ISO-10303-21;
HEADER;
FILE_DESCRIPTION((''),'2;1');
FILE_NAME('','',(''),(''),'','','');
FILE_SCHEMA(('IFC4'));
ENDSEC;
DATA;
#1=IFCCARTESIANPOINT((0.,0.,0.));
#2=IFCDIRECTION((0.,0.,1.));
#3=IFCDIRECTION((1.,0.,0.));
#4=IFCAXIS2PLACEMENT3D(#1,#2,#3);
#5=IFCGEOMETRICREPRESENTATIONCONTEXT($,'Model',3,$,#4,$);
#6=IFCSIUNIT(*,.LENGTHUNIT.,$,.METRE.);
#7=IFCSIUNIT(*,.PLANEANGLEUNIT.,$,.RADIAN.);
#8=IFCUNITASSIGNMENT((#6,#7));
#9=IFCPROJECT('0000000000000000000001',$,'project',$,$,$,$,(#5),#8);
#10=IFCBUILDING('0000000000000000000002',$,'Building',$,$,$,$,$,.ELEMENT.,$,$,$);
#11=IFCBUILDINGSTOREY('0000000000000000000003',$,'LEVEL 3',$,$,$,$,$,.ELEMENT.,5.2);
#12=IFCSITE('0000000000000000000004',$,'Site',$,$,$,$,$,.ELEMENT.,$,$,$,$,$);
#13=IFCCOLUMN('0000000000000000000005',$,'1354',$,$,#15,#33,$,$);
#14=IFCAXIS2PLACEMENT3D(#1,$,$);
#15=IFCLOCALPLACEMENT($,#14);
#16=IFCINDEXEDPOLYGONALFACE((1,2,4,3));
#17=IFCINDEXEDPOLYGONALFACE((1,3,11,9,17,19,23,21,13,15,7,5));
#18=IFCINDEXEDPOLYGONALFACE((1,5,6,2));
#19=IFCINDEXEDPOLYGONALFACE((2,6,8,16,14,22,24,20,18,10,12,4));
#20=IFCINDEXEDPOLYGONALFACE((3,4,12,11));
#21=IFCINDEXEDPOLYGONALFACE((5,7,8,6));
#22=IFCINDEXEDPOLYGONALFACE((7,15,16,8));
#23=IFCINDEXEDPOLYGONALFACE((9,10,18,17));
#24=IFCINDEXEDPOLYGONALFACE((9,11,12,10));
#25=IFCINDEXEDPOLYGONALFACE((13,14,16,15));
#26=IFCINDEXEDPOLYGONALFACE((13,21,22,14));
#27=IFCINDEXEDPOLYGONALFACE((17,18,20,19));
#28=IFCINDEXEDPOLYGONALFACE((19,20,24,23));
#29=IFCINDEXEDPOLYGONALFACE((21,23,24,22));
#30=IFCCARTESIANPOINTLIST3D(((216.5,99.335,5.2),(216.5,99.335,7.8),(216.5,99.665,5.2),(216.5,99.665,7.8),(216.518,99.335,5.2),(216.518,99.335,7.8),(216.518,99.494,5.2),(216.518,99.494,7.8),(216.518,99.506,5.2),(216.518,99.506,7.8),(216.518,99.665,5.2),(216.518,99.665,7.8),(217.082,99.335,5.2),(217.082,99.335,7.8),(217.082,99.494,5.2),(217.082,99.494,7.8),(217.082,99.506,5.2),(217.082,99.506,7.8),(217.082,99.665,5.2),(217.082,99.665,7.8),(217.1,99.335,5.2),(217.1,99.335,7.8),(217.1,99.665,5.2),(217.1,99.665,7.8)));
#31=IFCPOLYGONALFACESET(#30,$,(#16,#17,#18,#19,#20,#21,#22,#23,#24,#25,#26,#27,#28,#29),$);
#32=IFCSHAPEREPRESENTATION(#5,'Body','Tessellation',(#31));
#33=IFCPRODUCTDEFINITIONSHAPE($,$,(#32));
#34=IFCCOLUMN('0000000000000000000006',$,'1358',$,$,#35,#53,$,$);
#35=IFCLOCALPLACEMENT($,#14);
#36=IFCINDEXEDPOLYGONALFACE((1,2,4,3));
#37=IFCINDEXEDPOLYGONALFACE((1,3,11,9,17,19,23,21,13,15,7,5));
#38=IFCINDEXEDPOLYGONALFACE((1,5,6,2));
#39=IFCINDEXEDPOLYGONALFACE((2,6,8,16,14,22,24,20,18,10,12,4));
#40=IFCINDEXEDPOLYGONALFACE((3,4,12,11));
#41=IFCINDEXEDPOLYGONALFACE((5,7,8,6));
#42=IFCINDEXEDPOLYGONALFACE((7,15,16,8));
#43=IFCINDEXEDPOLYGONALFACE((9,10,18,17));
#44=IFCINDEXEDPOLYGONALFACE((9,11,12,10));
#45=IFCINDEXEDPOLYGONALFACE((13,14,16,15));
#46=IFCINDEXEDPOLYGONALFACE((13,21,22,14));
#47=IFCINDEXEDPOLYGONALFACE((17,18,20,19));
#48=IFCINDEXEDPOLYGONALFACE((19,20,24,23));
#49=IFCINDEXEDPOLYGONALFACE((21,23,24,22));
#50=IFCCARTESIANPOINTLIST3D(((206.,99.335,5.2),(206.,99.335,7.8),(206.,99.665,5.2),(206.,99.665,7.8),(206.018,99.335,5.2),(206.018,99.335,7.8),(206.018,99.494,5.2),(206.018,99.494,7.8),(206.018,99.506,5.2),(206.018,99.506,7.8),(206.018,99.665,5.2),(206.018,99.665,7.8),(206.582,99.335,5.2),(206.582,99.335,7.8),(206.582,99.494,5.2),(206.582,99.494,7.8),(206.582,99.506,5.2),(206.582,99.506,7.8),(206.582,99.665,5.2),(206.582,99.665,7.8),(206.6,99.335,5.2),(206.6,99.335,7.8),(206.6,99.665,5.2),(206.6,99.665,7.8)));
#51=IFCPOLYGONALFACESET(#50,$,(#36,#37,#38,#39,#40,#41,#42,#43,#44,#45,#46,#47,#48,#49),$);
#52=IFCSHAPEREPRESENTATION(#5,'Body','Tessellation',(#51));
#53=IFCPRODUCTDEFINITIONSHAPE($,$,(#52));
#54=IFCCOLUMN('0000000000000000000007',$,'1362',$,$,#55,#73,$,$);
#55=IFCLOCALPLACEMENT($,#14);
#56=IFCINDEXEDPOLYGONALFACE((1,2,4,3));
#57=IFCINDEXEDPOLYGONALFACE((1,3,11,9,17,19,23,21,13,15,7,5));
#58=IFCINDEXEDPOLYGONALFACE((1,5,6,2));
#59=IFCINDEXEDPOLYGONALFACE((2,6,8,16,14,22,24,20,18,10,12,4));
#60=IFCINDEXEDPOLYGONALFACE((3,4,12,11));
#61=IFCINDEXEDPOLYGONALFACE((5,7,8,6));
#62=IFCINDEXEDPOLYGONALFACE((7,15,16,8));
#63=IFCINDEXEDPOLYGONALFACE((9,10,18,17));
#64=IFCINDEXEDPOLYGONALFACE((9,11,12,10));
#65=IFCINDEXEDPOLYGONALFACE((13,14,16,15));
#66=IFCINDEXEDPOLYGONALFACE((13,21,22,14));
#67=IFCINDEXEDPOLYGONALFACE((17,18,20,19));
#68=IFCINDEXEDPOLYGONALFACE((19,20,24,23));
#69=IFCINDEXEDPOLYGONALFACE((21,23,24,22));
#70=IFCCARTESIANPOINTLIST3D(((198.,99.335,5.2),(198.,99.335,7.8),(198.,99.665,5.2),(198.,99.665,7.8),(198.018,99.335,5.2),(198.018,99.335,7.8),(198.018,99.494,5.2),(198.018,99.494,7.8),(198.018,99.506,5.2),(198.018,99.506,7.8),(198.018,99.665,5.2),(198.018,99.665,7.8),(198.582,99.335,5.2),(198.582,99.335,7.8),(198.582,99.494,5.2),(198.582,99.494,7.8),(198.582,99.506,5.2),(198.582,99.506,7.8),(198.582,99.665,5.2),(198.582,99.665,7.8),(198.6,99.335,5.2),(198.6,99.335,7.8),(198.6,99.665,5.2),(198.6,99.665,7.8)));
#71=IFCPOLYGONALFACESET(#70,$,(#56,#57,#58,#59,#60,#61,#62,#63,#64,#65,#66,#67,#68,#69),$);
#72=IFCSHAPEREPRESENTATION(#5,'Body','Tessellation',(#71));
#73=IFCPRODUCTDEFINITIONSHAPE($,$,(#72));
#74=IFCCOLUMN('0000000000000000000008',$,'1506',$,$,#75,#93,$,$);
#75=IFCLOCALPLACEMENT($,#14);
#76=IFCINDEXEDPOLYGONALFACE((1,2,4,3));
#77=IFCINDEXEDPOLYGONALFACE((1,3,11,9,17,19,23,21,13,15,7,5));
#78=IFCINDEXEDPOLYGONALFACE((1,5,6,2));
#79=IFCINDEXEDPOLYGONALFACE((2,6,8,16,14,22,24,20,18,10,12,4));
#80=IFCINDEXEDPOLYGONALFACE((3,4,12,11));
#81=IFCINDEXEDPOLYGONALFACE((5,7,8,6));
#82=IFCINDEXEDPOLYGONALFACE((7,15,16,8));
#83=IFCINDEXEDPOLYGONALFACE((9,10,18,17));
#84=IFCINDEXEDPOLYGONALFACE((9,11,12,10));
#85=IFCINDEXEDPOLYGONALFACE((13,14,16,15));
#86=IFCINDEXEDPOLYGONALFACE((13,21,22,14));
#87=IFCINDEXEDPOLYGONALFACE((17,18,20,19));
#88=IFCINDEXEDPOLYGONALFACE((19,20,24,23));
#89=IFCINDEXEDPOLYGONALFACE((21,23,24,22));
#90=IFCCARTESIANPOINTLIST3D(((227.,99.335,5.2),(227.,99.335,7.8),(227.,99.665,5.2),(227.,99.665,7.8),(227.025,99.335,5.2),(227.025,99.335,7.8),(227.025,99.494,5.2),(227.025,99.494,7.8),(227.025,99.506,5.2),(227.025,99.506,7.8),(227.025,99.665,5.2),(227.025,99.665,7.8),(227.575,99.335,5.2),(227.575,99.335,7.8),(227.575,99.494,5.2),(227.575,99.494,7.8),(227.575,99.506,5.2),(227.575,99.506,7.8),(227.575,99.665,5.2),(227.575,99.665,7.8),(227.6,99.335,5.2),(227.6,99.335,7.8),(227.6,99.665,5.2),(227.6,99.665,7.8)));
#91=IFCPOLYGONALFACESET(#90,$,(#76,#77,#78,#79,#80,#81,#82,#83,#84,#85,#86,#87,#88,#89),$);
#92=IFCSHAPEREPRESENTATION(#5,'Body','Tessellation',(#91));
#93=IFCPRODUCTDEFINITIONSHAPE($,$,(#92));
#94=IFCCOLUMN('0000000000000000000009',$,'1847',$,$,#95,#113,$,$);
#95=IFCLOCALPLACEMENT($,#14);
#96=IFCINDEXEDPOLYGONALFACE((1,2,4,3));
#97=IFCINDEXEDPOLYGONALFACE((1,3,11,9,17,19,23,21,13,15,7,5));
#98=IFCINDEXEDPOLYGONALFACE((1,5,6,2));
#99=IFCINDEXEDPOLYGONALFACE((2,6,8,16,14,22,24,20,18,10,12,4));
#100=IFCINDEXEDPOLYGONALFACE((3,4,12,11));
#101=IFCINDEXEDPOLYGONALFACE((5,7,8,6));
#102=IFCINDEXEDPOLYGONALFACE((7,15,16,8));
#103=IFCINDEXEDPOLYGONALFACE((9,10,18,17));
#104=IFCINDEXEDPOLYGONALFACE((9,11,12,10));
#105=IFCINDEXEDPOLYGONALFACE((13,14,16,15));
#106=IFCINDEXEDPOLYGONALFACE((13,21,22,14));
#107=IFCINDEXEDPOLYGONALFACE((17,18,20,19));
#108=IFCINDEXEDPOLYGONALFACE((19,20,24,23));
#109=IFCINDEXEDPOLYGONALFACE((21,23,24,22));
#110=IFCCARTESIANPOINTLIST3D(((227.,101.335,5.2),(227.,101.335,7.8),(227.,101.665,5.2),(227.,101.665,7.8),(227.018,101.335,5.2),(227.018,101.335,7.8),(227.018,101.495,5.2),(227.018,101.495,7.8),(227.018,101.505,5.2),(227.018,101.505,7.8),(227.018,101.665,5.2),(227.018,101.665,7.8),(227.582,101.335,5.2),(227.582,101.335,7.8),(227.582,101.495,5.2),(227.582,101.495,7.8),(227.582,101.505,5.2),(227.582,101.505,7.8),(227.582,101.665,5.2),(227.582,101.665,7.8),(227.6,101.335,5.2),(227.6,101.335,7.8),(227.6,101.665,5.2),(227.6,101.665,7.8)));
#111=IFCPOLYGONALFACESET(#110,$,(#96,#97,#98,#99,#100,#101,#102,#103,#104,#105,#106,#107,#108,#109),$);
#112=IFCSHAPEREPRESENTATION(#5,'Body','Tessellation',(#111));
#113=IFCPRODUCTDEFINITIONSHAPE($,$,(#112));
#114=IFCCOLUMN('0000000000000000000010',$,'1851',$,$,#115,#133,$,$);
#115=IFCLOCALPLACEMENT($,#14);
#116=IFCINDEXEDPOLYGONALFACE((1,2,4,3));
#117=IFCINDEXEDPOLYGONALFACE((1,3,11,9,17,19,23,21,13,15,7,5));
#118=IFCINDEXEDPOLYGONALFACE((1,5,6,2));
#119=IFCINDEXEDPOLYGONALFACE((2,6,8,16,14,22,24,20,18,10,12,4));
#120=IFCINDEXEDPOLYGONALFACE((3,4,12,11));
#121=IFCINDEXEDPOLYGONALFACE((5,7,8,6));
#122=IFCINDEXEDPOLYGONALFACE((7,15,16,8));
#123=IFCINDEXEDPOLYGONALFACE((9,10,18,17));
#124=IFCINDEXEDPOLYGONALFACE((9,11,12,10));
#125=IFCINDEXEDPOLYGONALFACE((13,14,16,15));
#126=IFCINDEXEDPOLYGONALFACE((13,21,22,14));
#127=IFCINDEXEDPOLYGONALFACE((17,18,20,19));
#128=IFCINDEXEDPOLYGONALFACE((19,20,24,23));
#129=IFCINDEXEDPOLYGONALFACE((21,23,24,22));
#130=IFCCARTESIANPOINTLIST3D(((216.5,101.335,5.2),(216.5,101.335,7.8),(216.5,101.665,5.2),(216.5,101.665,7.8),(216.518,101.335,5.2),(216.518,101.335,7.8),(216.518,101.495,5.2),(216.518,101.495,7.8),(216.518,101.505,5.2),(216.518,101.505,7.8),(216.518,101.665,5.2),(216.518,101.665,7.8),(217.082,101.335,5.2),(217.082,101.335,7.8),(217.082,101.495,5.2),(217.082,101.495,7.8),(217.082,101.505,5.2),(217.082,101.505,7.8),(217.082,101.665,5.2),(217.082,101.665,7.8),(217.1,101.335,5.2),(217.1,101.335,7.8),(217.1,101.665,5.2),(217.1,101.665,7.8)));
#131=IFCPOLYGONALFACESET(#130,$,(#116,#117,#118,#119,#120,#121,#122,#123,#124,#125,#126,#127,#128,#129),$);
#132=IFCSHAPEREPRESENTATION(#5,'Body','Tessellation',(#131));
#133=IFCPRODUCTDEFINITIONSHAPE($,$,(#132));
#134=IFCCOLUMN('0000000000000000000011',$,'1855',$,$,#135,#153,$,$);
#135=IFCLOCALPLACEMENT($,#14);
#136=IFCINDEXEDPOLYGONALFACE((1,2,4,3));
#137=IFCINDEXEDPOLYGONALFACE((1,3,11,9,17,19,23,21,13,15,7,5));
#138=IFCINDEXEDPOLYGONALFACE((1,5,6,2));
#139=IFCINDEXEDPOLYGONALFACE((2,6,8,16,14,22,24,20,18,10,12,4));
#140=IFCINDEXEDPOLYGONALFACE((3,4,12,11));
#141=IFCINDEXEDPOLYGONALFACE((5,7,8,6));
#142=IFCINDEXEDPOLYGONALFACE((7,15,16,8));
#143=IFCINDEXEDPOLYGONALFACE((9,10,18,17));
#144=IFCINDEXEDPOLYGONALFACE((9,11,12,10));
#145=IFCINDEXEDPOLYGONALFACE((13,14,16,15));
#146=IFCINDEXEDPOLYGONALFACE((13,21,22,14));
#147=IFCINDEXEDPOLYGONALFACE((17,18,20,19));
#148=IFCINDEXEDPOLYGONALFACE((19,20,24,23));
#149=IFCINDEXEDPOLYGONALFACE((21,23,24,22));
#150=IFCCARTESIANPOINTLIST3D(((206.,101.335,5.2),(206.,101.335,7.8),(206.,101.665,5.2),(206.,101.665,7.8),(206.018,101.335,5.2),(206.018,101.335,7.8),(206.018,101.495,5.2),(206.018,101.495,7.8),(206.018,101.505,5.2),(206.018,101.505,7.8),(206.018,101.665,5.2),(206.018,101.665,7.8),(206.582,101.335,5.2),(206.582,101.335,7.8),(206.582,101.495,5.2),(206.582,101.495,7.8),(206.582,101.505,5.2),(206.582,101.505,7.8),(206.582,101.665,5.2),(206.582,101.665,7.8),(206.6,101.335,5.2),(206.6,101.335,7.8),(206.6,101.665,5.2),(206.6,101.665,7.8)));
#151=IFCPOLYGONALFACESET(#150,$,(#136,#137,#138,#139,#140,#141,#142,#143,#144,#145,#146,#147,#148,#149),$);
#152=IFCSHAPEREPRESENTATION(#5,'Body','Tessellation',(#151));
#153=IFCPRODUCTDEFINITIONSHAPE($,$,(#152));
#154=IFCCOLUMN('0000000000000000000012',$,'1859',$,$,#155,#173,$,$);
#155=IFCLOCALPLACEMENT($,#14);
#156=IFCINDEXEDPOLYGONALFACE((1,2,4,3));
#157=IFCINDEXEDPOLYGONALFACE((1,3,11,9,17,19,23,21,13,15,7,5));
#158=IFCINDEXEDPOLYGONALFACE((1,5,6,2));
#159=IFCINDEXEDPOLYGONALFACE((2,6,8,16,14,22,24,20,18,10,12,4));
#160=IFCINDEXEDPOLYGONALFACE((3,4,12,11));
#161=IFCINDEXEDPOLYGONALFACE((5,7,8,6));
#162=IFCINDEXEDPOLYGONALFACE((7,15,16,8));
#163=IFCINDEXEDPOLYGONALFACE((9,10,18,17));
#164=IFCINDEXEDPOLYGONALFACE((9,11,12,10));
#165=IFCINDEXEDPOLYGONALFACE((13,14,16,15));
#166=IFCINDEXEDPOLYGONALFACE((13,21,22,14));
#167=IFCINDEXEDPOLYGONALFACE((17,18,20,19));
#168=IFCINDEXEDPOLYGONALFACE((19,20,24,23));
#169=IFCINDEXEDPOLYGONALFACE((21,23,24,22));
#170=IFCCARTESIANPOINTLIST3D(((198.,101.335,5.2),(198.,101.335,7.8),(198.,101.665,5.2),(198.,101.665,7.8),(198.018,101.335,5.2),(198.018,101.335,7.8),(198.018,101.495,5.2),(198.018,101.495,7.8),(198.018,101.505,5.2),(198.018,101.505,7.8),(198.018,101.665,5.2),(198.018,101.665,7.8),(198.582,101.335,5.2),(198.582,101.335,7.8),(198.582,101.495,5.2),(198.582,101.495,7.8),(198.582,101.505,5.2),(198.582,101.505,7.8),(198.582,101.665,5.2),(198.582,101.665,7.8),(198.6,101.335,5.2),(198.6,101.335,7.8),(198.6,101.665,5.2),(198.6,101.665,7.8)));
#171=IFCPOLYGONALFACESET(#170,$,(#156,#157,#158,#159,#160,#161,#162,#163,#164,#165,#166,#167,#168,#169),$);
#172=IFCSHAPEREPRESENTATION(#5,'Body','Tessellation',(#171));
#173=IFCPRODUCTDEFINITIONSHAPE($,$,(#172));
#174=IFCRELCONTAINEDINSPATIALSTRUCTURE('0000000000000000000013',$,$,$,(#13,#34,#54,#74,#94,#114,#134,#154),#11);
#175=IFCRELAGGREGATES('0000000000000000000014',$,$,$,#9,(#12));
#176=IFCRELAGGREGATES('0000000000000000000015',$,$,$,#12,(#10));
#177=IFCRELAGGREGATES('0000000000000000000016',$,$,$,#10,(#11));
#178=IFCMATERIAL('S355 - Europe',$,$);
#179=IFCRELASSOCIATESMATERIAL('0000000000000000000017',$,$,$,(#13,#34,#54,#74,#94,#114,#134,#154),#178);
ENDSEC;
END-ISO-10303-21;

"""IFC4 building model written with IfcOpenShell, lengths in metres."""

from ifc_helpers import new_model, si_unit, frame, origin_with_axes, origin_2d_with_axis, place, context, project, spatial, i_section, extrude, material, material_profile, profile_set, profile_usage, element, save


model = new_model("IFC4")

# Units and contexts
model_context = context("Model", 3, world=origin_with_axes())
ifc_project = project(units=[si_unit("LENGTHUNIT", "METRE"), si_unit("PLANEANGLEUNIT", "RADIAN")], contexts=[model_context])

# Site, building, storey
site = spatial("IfcSite", under=ifc_project, Name="Site", CompositionType="ELEMENT")
building = spatial("IfcBuilding", under=site, Name="Building", CompositionType="ELEMENT")
storey = spatial("IfcBuildingStorey", under=building, Name="LEVEL 3", CompositionType="ELEMENT", Elevation=5.2)

# Columns
ifc_material = material(Name="S355 - Europe")
ifc_material_profile_1 = material_profile(ifc_material, i_section(OverallWidth=0.33, OverallDepth=0.6, WebThickness=0.012, FlangeThickness=0.018, at=origin_2d_with_axis()))
ifc_profile_set_1 = profile_set([ifc_material_profile_1])
ifc_profile_usage_1 = profile_usage(ifc_profile_set_1, cardinal=10)
column_1_placement = place(None, frame((216.8, 99.5, 5.2), z_axis=(0.0, 0.0, 1.0), x_axis=(0.0, -1.0, 0.0)))
element("IfcColumn", 1, at=column_1_placement, inside=storey, material=ifc_profile_usage_1, Name="1354", context=model_context, shape_type="SweptSolid", body=[
    extrude(i_section(OverallWidth=0.33, OverallDepth=0.6, WebThickness=0.012, FlangeThickness=0.018, at=origin_2d_with_axis()), origin_with_axes(), (0.0, 0.0, 1.0), 2.6),
])
ifc_material_profile_2 = material_profile(ifc_material, i_section(OverallWidth=0.33, OverallDepth=0.6, WebThickness=0.012, FlangeThickness=0.018, at=origin_2d_with_axis()))
ifc_profile_set_2 = profile_set([ifc_material_profile_2])
ifc_profile_usage_2 = profile_usage(ifc_profile_set_2, cardinal=10)
column_2_placement = place(None, frame((206.3, 99.5, 5.2), z_axis=(0.0, 0.0, 1.0), x_axis=(0.0, -1.0, 0.0)))
element("IfcColumn", 2, at=column_2_placement, inside=storey, material=ifc_profile_usage_2, Name="1358", context=model_context, shape_type="SweptSolid", body=[
    extrude(i_section(OverallWidth=0.33, OverallDepth=0.6, WebThickness=0.012, FlangeThickness=0.018, at=origin_2d_with_axis()), origin_with_axes(), (0.0, 0.0, 1.0), 2.6),
])
ifc_material_profile_3 = material_profile(ifc_material, i_section(OverallWidth=0.33, OverallDepth=0.6, WebThickness=0.012, FlangeThickness=0.018, at=origin_2d_with_axis()))
ifc_profile_set_3 = profile_set([ifc_material_profile_3])
ifc_profile_usage_3 = profile_usage(ifc_profile_set_3, cardinal=10)
column_3_placement = place(None, frame((198.3, 99.5, 5.2), z_axis=(0.0, 0.0, 1.0), x_axis=(0.0, -1.0, 0.0)))
element("IfcColumn", 3, at=column_3_placement, inside=storey, material=ifc_profile_usage_3, Name="1362", context=model_context, shape_type="SweptSolid", body=[
    extrude(i_section(OverallWidth=0.33, OverallDepth=0.6, WebThickness=0.012, FlangeThickness=0.018, at=origin_2d_with_axis()), origin_with_axes(), (0.0, 0.0, 1.0), 2.6),
])
ifc_material_profile_4 = material_profile(ifc_material, i_section(OverallWidth=0.33, OverallDepth=0.6, WebThickness=0.012, FlangeThickness=0.025, at=origin_2d_with_axis()))
ifc_profile_set_4 = profile_set([ifc_material_profile_4])
ifc_profile_usage_4 = profile_usage(ifc_profile_set_4, cardinal=10)
column_4_placement = place(None, frame((227.3, 99.5, 5.2), z_axis=(0.0, 0.0, 1.0), x_axis=(0.0, -1.0, 0.0)))
element("IfcColumn", 4, at=column_4_placement, inside=storey, material=ifc_profile_usage_4, Name="1506", context=model_context, shape_type="SweptSolid", body=[
    extrude(i_section(OverallWidth=0.33, OverallDepth=0.6, WebThickness=0.012, FlangeThickness=0.025, at=origin_2d_with_axis()), origin_with_axes(), (0.0, 0.0, 1.0), 2.6),
])
ifc_material_profile_5 = material_profile(ifc_material, i_section(OverallWidth=0.33, OverallDepth=0.6, WebThickness=0.01, FlangeThickness=0.018, at=origin_2d_with_axis()))
ifc_profile_set_5 = profile_set([ifc_material_profile_5])
ifc_profile_usage_5 = profile_usage(ifc_profile_set_5, cardinal=10)
column_5_placement = place(None, frame((227.3, 101.5, 5.2), z_axis=(0.0, 0.0, 1.0), x_axis=(0.0, -1.0, 0.0)))
element("IfcColumn", 5, at=column_5_placement, inside=storey, material=ifc_profile_usage_5, Name="1847", context=model_context, shape_type="SweptSolid", body=[
    extrude(i_section(OverallWidth=0.33, OverallDepth=0.6, WebThickness=0.01, FlangeThickness=0.018, at=origin_2d_with_axis()), origin_with_axes(), (0.0, 0.0, 1.0), 2.6),
])
ifc_material_profile_6 = material_profile(ifc_material, i_section(OverallWidth=0.33, OverallDepth=0.6, WebThickness=0.01, FlangeThickness=0.018, at=origin_2d_with_axis()))
ifc_profile_set_6 = profile_set([ifc_material_profile_6])
ifc_profile_usage_6 = profile_usage(ifc_profile_set_6, cardinal=10)
column_6_placement = place(None, frame((216.8, 101.5, 5.2), z_axis=(0.0, 0.0, 1.0), x_axis=(0.0, -1.0, 0.0)))
element("IfcColumn", 6, at=column_6_placement, inside=storey, material=ifc_profile_usage_6, Name="1851", context=model_context, shape_type="SweptSolid", body=[
    extrude(i_section(OverallWidth=0.33, OverallDepth=0.6, WebThickness=0.01, FlangeThickness=0.018, at=origin_2d_with_axis()), origin_with_axes(), (0.0, 0.0, 1.0), 2.6),
])
ifc_material_profile_7 = material_profile(ifc_material, i_section(OverallWidth=0.33, OverallDepth=0.6, WebThickness=0.01, FlangeThickness=0.018, at=origin_2d_with_axis()))
ifc_profile_set_7 = profile_set([ifc_material_profile_7])
ifc_profile_usage_7 = profile_usage(ifc_profile_set_7, cardinal=10)
column_7_placement = place(None, frame((206.3, 101.5, 5.2), z_axis=(0.0, 0.0, 1.0), x_axis=(0.0, -1.0, 0.0)))
element("IfcColumn", 7, at=column_7_placement, inside=storey, material=ifc_profile_usage_7, Name="1855", context=model_context, shape_type="SweptSolid", body=[
    extrude(i_section(OverallWidth=0.33, OverallDepth=0.6, WebThickness=0.01, FlangeThickness=0.018, at=origin_2d_with_axis()), origin_with_axes(), (0.0, 0.0, 1.0), 2.6),
])
ifc_material_profile_8 = material_profile(ifc_material, i_section(OverallWidth=0.33, OverallDepth=0.6, WebThickness=0.01, FlangeThickness=0.018, at=origin_2d_with_axis()))
ifc_profile_set_8 = profile_set([ifc_material_profile_8])
ifc_profile_usage_8 = profile_usage(ifc_profile_set_8, cardinal=10)
column_8_placement = place(None, frame((198.3, 101.5, 5.2), z_axis=(0.0, 0.0, 1.0), x_axis=(0.0, -1.0, 0.0)))
element("IfcColumn", 8, at=column_8_placement, inside=storey, material=ifc_profile_usage_8, Name="1859", context=model_context, shape_type="SweptSolid", body=[
    extrude(i_section(OverallWidth=0.33, OverallDepth=0.6, WebThickness=0.01, FlangeThickness=0.018, at=origin_2d_with_axis()), origin_with_axes(), (0.0, 0.0, 1.0), 2.6),
])

save(model, "model.ifc")
